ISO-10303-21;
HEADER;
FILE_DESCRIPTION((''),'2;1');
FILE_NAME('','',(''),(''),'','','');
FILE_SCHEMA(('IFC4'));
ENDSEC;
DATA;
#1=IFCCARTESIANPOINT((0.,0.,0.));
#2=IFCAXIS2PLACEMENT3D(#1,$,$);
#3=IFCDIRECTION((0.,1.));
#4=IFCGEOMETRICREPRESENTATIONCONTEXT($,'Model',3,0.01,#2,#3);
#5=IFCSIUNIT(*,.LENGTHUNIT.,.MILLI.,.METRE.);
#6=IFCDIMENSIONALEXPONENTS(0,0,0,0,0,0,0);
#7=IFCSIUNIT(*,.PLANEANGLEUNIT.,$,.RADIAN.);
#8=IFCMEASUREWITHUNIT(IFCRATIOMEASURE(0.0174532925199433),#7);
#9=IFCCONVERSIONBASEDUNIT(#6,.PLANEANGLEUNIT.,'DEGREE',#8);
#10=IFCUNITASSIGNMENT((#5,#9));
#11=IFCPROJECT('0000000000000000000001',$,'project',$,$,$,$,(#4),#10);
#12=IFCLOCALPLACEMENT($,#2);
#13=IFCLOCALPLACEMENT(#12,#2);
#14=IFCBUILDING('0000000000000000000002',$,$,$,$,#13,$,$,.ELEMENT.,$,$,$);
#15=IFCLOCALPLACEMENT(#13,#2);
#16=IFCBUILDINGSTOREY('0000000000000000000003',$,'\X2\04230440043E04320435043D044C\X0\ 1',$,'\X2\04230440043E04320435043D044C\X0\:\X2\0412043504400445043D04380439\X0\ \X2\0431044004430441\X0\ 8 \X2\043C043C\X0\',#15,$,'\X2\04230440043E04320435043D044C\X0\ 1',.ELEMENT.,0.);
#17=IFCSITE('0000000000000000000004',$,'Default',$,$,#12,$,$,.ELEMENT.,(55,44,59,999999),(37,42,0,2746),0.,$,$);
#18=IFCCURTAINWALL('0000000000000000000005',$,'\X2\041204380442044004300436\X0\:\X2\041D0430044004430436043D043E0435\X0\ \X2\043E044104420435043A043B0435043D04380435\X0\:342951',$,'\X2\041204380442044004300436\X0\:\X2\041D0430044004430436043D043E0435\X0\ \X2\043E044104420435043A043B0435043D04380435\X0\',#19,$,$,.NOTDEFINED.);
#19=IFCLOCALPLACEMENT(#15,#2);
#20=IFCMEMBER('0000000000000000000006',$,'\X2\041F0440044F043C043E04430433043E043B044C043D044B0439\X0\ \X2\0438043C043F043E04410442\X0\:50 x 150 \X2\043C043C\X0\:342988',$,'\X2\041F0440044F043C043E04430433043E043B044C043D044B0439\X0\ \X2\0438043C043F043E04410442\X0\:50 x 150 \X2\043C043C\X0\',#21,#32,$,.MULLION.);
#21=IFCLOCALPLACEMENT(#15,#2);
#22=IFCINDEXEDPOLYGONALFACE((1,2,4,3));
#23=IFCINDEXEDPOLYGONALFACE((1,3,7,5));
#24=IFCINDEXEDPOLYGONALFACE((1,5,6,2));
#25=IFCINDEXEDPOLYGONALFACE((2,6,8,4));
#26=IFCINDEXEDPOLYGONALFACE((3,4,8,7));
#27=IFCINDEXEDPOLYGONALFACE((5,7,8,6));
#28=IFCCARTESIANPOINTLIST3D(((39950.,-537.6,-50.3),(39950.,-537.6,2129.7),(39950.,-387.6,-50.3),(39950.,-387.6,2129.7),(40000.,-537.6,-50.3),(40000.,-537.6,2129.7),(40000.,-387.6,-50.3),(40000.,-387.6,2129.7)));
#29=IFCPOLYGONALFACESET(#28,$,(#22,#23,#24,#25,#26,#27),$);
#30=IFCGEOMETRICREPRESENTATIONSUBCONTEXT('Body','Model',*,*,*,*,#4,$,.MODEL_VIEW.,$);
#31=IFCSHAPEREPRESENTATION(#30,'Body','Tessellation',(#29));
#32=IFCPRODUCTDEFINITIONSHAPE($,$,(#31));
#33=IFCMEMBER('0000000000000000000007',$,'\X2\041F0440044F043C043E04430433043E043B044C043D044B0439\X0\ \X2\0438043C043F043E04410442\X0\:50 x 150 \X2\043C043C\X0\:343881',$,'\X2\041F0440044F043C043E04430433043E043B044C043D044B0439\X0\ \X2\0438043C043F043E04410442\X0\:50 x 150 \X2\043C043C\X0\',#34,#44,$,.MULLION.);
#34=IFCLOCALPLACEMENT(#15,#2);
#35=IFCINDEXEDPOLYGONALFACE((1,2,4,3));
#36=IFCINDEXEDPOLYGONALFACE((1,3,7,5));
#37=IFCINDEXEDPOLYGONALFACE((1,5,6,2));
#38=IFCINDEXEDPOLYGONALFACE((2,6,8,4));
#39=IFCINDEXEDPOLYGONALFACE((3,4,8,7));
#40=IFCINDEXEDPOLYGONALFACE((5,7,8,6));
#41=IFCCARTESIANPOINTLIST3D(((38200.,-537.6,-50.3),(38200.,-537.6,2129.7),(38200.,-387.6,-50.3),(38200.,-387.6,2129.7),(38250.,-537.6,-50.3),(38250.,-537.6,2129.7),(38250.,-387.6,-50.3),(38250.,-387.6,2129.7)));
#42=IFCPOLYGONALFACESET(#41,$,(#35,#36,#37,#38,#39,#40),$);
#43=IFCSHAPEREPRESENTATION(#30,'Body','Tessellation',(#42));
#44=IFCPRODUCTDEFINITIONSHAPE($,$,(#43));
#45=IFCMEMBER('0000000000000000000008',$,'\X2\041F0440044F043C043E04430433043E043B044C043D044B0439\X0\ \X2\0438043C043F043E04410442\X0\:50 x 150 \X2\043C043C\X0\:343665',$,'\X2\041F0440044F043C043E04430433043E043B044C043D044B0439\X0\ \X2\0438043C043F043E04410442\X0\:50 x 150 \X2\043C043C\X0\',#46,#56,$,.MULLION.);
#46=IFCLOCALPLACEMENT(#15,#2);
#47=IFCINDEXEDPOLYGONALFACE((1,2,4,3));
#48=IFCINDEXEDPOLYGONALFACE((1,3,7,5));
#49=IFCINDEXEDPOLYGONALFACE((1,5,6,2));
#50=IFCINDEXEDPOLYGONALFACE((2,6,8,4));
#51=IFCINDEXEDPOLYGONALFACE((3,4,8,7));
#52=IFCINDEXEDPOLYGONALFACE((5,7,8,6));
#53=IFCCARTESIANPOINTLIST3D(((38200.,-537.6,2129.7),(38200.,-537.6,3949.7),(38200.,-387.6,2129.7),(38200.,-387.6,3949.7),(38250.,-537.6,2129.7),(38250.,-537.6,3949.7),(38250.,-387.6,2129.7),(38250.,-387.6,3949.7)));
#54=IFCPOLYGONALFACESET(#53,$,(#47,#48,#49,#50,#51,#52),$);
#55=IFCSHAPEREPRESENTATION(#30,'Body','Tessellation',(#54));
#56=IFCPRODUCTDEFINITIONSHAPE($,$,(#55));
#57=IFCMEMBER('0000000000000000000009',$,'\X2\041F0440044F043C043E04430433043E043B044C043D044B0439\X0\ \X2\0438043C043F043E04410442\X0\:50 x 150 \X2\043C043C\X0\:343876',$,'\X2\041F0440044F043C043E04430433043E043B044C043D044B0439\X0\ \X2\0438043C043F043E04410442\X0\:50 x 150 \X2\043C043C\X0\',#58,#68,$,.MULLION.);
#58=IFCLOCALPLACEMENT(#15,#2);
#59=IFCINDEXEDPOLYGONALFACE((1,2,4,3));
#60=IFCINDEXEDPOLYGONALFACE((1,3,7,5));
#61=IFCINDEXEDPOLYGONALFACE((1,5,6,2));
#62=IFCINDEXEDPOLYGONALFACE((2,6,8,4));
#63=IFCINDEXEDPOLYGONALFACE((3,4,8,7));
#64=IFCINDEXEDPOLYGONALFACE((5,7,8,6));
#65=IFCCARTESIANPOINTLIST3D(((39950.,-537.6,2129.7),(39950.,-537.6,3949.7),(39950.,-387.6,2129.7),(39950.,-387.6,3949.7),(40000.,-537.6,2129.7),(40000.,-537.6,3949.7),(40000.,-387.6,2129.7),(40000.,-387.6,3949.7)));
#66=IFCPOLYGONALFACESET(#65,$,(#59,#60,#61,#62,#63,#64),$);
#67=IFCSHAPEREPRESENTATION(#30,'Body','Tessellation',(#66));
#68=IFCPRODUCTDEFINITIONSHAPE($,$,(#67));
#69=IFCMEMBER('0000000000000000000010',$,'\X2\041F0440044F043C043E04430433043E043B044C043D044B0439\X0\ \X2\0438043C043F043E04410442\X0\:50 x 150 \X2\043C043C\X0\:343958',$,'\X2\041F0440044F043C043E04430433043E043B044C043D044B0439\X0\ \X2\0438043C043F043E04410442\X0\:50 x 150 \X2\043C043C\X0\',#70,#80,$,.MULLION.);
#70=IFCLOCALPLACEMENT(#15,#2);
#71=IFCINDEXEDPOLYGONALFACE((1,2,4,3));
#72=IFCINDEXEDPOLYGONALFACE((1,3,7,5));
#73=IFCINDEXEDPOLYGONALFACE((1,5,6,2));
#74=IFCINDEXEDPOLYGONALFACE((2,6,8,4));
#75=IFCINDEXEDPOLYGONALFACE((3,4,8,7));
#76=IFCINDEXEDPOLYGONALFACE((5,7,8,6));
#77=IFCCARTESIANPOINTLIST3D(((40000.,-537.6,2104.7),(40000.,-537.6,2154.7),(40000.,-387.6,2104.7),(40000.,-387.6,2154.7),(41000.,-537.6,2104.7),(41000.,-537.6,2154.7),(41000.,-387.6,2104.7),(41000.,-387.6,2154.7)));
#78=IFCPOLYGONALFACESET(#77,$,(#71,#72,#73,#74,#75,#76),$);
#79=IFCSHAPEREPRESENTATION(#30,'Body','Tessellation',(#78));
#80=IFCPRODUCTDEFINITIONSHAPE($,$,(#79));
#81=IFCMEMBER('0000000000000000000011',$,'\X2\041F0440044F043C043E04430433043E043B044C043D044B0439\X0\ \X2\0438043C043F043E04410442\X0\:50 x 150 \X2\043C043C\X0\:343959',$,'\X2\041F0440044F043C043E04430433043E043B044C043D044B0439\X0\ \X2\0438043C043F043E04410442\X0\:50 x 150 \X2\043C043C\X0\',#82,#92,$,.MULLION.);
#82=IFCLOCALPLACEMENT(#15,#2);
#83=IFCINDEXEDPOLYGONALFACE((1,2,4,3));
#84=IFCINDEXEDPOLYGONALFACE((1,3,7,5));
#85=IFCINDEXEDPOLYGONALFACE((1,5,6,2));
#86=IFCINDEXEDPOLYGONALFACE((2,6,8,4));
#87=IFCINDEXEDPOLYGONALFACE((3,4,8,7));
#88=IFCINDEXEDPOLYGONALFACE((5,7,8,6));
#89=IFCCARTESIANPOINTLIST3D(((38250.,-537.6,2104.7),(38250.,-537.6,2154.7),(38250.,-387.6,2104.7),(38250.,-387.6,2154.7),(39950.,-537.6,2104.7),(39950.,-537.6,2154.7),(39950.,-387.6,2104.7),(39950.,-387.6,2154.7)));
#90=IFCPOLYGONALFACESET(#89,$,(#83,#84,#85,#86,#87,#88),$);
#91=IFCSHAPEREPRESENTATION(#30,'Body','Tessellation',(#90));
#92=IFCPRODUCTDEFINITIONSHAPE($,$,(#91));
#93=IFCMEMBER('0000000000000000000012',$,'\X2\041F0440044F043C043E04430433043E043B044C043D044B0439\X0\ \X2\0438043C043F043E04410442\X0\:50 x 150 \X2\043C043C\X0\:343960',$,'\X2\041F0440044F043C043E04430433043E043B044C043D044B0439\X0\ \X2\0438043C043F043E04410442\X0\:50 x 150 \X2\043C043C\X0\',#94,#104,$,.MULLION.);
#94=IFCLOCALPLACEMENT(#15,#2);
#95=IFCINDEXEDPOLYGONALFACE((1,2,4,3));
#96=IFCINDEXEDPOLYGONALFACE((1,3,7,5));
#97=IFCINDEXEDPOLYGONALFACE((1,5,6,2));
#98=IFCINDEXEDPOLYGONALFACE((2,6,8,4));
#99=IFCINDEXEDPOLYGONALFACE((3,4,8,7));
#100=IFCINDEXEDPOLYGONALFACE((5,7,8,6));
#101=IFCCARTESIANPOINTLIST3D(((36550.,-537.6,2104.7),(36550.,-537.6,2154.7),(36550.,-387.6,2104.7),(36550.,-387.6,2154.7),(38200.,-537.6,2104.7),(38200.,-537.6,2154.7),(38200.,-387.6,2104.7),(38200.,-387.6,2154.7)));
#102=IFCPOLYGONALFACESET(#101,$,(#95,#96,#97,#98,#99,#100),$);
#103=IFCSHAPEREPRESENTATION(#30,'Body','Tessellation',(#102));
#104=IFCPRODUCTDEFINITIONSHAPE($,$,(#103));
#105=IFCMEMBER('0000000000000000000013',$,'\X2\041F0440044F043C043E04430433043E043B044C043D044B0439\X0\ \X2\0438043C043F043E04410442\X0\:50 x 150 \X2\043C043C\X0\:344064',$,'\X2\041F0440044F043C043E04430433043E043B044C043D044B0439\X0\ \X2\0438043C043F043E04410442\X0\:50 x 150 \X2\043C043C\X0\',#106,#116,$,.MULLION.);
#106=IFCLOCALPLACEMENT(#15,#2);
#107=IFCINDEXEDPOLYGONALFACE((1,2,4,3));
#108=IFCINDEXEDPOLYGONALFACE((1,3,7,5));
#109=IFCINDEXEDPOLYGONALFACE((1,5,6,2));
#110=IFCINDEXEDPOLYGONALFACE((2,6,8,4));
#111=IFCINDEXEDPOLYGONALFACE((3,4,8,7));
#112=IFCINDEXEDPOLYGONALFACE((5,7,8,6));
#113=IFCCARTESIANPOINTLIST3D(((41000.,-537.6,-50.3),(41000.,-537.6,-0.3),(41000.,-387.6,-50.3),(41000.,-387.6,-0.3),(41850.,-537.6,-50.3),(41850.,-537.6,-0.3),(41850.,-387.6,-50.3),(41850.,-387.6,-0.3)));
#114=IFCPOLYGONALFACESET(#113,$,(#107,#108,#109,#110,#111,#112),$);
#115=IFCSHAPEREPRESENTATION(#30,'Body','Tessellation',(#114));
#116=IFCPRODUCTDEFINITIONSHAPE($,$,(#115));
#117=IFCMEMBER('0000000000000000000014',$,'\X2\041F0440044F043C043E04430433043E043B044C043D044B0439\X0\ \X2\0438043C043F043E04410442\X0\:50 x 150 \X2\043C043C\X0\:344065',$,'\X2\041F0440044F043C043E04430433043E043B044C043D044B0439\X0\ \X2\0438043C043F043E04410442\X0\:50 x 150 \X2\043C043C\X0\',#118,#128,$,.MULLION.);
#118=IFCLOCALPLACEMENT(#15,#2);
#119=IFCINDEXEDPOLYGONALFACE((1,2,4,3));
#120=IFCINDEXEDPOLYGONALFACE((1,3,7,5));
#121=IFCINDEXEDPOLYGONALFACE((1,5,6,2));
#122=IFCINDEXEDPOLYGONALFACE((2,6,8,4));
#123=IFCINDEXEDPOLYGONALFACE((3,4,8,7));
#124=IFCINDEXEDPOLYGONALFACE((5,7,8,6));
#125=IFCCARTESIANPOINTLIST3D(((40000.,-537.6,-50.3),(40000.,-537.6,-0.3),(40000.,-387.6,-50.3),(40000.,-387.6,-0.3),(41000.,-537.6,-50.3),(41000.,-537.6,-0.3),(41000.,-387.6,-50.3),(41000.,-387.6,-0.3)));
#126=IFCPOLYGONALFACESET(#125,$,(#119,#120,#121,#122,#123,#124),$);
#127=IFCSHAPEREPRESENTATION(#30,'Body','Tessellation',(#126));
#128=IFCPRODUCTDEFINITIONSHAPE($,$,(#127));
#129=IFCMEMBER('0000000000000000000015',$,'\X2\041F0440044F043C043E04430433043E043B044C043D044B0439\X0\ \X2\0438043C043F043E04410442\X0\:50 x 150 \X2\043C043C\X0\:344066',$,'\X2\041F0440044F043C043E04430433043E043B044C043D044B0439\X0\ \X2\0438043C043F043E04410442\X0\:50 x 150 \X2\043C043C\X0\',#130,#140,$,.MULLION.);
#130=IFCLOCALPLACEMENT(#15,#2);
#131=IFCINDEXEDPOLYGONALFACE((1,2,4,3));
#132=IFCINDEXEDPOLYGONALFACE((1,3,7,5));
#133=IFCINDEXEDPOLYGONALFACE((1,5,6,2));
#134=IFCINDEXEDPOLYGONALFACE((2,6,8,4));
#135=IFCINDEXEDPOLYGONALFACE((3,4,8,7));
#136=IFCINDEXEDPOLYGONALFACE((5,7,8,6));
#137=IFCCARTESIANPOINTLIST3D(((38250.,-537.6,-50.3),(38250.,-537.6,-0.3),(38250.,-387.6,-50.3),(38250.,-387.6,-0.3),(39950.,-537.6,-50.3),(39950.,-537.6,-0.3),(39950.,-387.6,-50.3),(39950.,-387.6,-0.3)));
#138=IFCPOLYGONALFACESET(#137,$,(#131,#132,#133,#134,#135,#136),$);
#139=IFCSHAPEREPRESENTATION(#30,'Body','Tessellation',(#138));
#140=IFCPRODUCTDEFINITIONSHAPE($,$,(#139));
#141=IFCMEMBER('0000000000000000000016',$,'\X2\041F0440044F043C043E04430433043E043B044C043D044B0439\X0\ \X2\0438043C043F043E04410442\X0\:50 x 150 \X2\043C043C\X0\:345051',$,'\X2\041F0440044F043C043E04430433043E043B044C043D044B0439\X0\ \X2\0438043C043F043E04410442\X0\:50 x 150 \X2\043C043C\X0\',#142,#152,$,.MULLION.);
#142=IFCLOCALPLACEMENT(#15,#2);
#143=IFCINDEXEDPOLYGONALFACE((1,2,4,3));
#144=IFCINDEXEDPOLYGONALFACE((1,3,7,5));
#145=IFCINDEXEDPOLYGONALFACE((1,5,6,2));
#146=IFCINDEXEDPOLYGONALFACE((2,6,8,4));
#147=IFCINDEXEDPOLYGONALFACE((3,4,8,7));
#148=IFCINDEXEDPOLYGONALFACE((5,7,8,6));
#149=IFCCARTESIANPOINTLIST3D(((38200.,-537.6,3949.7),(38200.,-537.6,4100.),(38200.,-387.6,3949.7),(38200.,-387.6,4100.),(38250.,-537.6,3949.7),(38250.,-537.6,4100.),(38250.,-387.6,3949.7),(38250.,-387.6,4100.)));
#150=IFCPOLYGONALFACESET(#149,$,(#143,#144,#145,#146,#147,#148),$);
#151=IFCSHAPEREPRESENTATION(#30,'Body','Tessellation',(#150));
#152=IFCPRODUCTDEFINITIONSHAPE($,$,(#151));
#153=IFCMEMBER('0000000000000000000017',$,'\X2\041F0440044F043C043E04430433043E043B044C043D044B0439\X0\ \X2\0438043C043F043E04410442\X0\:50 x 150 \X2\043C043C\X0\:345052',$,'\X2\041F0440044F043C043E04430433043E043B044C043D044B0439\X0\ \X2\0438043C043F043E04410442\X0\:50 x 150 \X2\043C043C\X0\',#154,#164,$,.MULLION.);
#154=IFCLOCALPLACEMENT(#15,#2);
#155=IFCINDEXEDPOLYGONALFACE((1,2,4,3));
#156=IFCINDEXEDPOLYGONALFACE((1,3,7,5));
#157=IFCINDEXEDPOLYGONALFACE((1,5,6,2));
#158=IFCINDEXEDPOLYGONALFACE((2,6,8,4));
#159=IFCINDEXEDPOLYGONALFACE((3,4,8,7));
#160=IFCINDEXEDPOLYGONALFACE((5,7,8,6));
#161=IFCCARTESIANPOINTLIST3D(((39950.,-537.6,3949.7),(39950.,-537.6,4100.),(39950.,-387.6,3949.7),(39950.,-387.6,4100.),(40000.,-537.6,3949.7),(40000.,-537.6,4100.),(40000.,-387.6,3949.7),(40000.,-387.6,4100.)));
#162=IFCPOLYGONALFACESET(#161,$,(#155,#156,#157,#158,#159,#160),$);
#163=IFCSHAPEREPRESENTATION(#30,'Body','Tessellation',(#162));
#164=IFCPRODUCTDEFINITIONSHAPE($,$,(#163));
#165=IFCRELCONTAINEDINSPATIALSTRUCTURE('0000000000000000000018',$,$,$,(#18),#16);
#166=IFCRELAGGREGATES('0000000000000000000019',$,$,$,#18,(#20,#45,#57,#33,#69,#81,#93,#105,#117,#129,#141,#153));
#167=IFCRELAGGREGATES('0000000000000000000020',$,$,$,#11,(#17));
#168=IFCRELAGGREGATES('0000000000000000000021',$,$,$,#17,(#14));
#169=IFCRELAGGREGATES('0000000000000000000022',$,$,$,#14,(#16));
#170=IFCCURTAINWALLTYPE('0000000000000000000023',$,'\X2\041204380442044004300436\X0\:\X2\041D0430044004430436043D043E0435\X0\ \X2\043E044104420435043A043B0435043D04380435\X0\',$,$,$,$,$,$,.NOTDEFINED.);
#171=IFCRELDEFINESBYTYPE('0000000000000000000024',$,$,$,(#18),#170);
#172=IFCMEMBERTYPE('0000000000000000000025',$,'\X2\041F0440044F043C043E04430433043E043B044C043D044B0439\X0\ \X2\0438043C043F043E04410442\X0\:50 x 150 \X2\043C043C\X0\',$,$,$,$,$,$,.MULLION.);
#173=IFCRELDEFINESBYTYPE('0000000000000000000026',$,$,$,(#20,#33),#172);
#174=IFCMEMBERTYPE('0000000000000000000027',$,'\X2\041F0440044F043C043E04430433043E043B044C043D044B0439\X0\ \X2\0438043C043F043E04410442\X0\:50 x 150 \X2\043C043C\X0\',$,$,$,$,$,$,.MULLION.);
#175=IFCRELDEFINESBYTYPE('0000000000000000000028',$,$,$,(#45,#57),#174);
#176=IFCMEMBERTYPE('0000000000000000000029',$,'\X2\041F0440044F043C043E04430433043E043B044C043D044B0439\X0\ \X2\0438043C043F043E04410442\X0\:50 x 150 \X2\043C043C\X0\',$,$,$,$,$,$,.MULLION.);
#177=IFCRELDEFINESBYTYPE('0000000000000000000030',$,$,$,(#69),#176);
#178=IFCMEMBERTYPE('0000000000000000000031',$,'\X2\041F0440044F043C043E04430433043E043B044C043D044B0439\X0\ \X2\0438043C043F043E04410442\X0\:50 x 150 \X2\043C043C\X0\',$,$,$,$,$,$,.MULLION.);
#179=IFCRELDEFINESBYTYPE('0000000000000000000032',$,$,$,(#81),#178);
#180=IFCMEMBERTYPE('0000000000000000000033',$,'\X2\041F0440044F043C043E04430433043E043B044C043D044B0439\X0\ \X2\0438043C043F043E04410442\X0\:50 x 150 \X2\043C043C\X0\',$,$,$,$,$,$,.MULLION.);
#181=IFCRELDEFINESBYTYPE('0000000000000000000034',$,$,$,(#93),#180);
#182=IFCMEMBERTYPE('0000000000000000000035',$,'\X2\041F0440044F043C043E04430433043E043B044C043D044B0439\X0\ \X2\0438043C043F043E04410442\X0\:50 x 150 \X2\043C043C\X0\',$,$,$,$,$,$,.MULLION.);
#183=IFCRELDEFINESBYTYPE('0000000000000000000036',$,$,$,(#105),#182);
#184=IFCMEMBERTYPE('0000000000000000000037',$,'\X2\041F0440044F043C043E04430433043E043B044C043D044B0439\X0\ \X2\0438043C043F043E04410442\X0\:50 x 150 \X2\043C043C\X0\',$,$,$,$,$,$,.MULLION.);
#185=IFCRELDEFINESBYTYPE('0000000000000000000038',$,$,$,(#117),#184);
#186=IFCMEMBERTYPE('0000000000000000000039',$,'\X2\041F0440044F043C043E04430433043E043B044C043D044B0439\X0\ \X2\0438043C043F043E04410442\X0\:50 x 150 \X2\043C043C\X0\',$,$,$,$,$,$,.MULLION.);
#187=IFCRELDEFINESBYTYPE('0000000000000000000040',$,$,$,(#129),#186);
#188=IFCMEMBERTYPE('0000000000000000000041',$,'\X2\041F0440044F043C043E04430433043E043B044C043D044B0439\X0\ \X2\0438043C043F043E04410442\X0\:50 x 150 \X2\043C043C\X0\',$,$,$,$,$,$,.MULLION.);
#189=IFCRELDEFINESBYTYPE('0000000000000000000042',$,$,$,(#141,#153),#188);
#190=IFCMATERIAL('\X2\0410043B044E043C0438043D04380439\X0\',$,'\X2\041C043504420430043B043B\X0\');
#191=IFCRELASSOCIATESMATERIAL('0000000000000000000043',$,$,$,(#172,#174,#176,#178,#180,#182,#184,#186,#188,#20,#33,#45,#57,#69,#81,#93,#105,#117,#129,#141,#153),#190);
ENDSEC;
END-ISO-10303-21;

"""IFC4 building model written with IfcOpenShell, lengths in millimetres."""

from ifc_helpers import new_model, entity, si_unit, converted_unit, direction, frame, origin, origin_2d_with_axis, place, context, subcontext, project, spatial, rectangle, extrude, source, transform, mapped, material, material_profile, profile_set, profile_usage, type_object, type_shapes, element, aggregate, save


model = new_model("IFC4")

# Units and contexts
model_context = context("Model", 3, precision=0.01, world=origin(), true_north=direction((0.0, 1.0)))
body_context = subcontext(model_context, "Body", "Model", "MODEL_VIEW")
ifc_project = project(units=[si_unit("LENGTHUNIT", "METRE", prefix="MILLI"), converted_unit("PLANEANGLEUNIT", "DEGREE", entity("IfcRatioMeasure", 0.0174532925199433), si_unit("PLANEANGLEUNIT", "RADIAN"), dimensions=[0, 0, 0, 0, 0, 0, 0])], contexts=[model_context])

# Site, building, storey
site_placement = place(None, origin())
site = spatial("IfcSite", under=ifc_project, at=site_placement, Name="Default", CompositionType="ELEMENT", RefLatitude=(55, 44, 59, 999999), RefLongitude=(37, 42, 0, 2746), RefElevation=0.0)
building_placement = place(site_placement, origin())
building = spatial("IfcBuilding", under=site, at=building_placement, CompositionType="ELEMENT")
storey_placement = place(building_placement, origin())
storey = spatial("IfcBuildingStorey", under=building, at=storey_placement, Name="Уровень 1", ObjectType="Уровень:Верхний брус 8 мм", LongName="Уровень 1", CompositionType="ELEMENT", Elevation=0.0)

# Curtain wall, members
curtain_wall_type = type_object("IfcCurtainWallType", Name="Витраж:Наружное остекление", PredefinedType="NOTDEFINED")
curtain_wall_placement = place(storey_placement, origin())
curtain_wall = element("IfcCurtainWall", 1, at=curtain_wall_placement, inside=storey, type_object=curtain_wall_type, Name="Витраж:Наружное остекление:342951", ObjectType="Витраж:Наружное остекление", PredefinedType="NOTDEFINED")
ifc_material_1 = material(Name="Алюминий", Category="Металл")
ifc_material_profile = material_profile(ifc_material_1, rectangle(XDim=150.0, YDim=50.0, at=origin_2d_with_axis()), Name="50 x 150 мм")
ifc_profile_set = profile_set([ifc_material_profile], Name="50 x 150 мм")
ifc_profile_usage_1 = profile_usage(ifc_profile_set)
member_type_1 = type_object("IfcMemberType", Name="Прямоугольный импост:50 x 150 мм", PredefinedType="MULLION", material=ifc_profile_set)
shared_shape_1 = source(origin(), body_context, "Body", "SweptSolid", [
    extrude(rectangle(XDim=150.0, YDim=50.0, at=origin_2d_with_axis()), frame((0.0, 0.0, -2180.0), z_axis=(0.0, 0.0, 1.0), x_axis=(0.0, -1.0, 0.0)), (0.0, 0.0, 1.0), 2180.0),
])
type_shapes(member_type_1, [shared_shape_1])
member_1_placement = place(storey_placement, frame((39975.0, -462.6, -50.3), z_axis=(0.0, 0.0, -1.0), x_axis=(1.0, 0.0, 0.0)))
member_1 = element("IfcMember", 2, at=member_1_placement, type_object=member_type_1, material=ifc_profile_usage_1, Name="Прямоугольный импост:50 x 150 мм:342988", ObjectType="Прямоугольный импост:50 x 150 мм", PredefinedType="MULLION", context=body_context, shape_type="MappedRepresentation", body=[
    mapped(shared_shape_1, transform((0.0, 0.0, 0.0), scale=1.0)),
])
ifc_profile_usage_2 = profile_usage(ifc_profile_set)
member_2_placement = place(storey_placement, frame((38225.0, -462.6, -50.3), z_axis=(0.0, 0.0, -1.0), x_axis=(1.0, 0.0, 0.0)))
member_2 = element("IfcMember", 3, at=member_2_placement, type_object=member_type_1, material=ifc_profile_usage_2, Name="Прямоугольный импост:50 x 150 мм:343881", ObjectType="Прямоугольный импост:50 x 150 мм", PredefinedType="MULLION", context=body_context, shape_type="MappedRepresentation", body=[
    mapped(shared_shape_1, transform((0.0, 0.0, 0.0), scale=1.0)),
])
ifc_profile_usage_3 = profile_usage(ifc_profile_set)
member_type_2 = type_object("IfcMemberType", Name="Прямоугольный импост:50 x 150 мм", PredefinedType="MULLION", material=ifc_profile_set)
shared_shape_2 = source(origin(), body_context, "Body", "SweptSolid", [
    extrude(rectangle(XDim=150.0, YDim=50.0, at=origin_2d_with_axis()), frame((0.0, 0.0, -1820.0), z_axis=(0.0, 0.0, 1.0), x_axis=(0.0, -1.0, 0.0)), (0.0, 0.0, 1.0), 1820.0),
])
type_shapes(member_type_2, [shared_shape_2])
member_3_placement = place(storey_placement, frame((38225.0, -462.6, 2129.7), z_axis=(0.0, 0.0, -1.0), x_axis=(1.0, 0.0, 0.0)))
member_3 = element("IfcMember", 4, at=member_3_placement, type_object=member_type_2, material=ifc_profile_usage_3, Name="Прямоугольный импост:50 x 150 мм:343665", ObjectType="Прямоугольный импост:50 x 150 мм", PredefinedType="MULLION", context=body_context, shape_type="MappedRepresentation", body=[
    mapped(shared_shape_2, transform((0.0, 0.0, 0.0), scale=1.0)),
])
ifc_profile_usage_4 = profile_usage(ifc_profile_set)
member_4_placement = place(storey_placement, frame((39975.0, -462.6, 2129.7), z_axis=(0.0, 0.0, -1.0), x_axis=(1.0, 0.0, 0.0)))
member_4 = element("IfcMember", 5, at=member_4_placement, type_object=member_type_2, material=ifc_profile_usage_4, Name="Прямоугольный импост:50 x 150 мм:343876", ObjectType="Прямоугольный импост:50 x 150 мм", PredefinedType="MULLION", context=body_context, shape_type="MappedRepresentation", body=[
    mapped(shared_shape_2, transform((0.0, 0.0, 0.0), scale=1.0)),
])
ifc_profile_usage_5 = profile_usage(ifc_profile_set)
member_type_3 = type_object("IfcMemberType", Name="Прямоугольный импост:50 x 150 мм", PredefinedType="MULLION", material=ifc_profile_set)
shared_shape_3 = source(origin(), body_context, "Body", "SweptSolid", [
    extrude(rectangle(XDim=150.0, YDim=50.0, at=origin_2d_with_axis()), frame((0.0, 0.0, -1000.0), z_axis=(0.0, 0.0, 1.0), x_axis=(0.0, -1.0, 0.0)), (0.0, 0.0, 1.0), 1000.0),
])
type_shapes(member_type_3, [shared_shape_3])
member_5_placement = place(storey_placement, frame((41000.0, -462.6, 2129.7), z_axis=(1.0, 0.0, 0.0), x_axis=(0.0, 0.0, 1.0)))
member_5 = element("IfcMember", 6, at=member_5_placement, type_object=member_type_3, material=ifc_profile_usage_5, Name="Прямоугольный импост:50 x 150 мм:343958", ObjectType="Прямоугольный импост:50 x 150 мм", PredefinedType="MULLION", context=body_context, shape_type="MappedRepresentation", body=[
    mapped(shared_shape_3, transform((0.0, 0.0, 0.0), scale=1.0)),
])
ifc_profile_usage_6 = profile_usage(ifc_profile_set)
member_type_4 = type_object("IfcMemberType", Name="Прямоугольный импост:50 x 150 мм", PredefinedType="MULLION", material=ifc_profile_set)
shared_shape_4 = source(origin(), body_context, "Body", "SweptSolid", [
    extrude(rectangle(XDim=150.0, YDim=50.0, at=origin_2d_with_axis()), frame((0.0, 0.0, -1700.0), z_axis=(0.0, 0.0, 1.0), x_axis=(0.0, -1.0, 0.0)), (0.0, 0.0, 1.0), 1700.0),
])
type_shapes(member_type_4, [shared_shape_4])
member_6_placement = place(storey_placement, frame((39950.0, -462.6, 2129.7), z_axis=(1.0, 0.0, 0.0), x_axis=(0.0, 0.0, 1.0)))
member_6 = element("IfcMember", 7, at=member_6_placement, type_object=member_type_4, material=ifc_profile_usage_6, Name="Прямоугольный импост:50 x 150 мм:343959", ObjectType="Прямоугольный импост:50 x 150 мм", PredefinedType="MULLION", context=body_context, shape_type="MappedRepresentation", body=[
    mapped(shared_shape_4, transform((0.0, 0.0, 0.0), scale=1.0)),
])
ifc_profile_usage_7 = profile_usage(ifc_profile_set)
member_type_5 = type_object("IfcMemberType", Name="Прямоугольный импост:50 x 150 мм", PredefinedType="MULLION", material=ifc_profile_set)
shared_shape_5 = source(origin(), body_context, "Body", "SweptSolid", [
    extrude(rectangle(XDim=150.0, YDim=50.0, at=origin_2d_with_axis()), frame((0.0, 0.0, -1650.0), z_axis=(0.0, 0.0, 1.0), x_axis=(0.0, -1.0, 0.0)), (0.0, 0.0, 1.0), 1650.0),
])
type_shapes(member_type_5, [shared_shape_5])
member_7_placement = place(storey_placement, frame((38200.0, -462.6, 2129.7), z_axis=(1.0, 0.0, 0.0), x_axis=(0.0, 0.0, 1.0)))
member_7 = element("IfcMember", 8, at=member_7_placement, type_object=member_type_5, material=ifc_profile_usage_7, Name="Прямоугольный импост:50 x 150 мм:343960", ObjectType="Прямоугольный импост:50 x 150 мм", PredefinedType="MULLION", context=body_context, shape_type="MappedRepresentation", body=[
    mapped(shared_shape_5, transform((0.0, 0.0, 0.0), scale=1.0)),
])
ifc_profile_usage_8 = profile_usage(ifc_profile_set)
member_type_6 = type_object("IfcMemberType", Name="Прямоугольный импост:50 x 150 мм", PredefinedType="MULLION", material=ifc_profile_set)
shared_shape_6 = source(origin(), body_context, "Body", "SweptSolid", [
    extrude(rectangle(XDim=150.0, YDim=50.0, at=origin_2d_with_axis()), frame((-25.0, 0.0, -850.0), z_axis=(0.0, 0.0, 1.0), x_axis=(0.0, -1.0, 0.0)), (0.0, 0.0, 1.0), 850.0),
])
type_shapes(member_type_6, [shared_shape_6])
member_8_placement = place(storey_placement, frame((41000.0, -462.6, -50.3), z_axis=(-1.0, 0.0, 0.0), x_axis=(0.0, 0.0, -1.0)))
member_8 = element("IfcMember", 9, at=member_8_placement, type_object=member_type_6, material=ifc_profile_usage_8, Name="Прямоугольный импост:50 x 150 мм:344064", ObjectType="Прямоугольный импост:50 x 150 мм", PredefinedType="MULLION", context=body_context, shape_type="MappedRepresentation", body=[
    mapped(shared_shape_6, transform((0.0, 0.0, 0.0), scale=1.0)),
])
ifc_profile_usage_9 = profile_usage(ifc_profile_set)
member_type_7 = type_object("IfcMemberType", Name="Прямоугольный импост:50 x 150 мм", PredefinedType="MULLION", material=ifc_profile_set)
shared_shape_7 = source(origin(), body_context, "Body", "SweptSolid", [
    extrude(rectangle(XDim=150.0, YDim=50.0, at=origin_2d_with_axis()), frame((-25.0, 0.0, -1000.0), z_axis=(0.0, 0.0, 1.0), x_axis=(0.0, -1.0, 0.0)), (0.0, 0.0, 1.0), 1000.0),
])
type_shapes(member_type_7, [shared_shape_7])
member_9_placement = place(storey_placement, frame((40000.0, -462.6, -50.3), z_axis=(-1.0, 0.0, 0.0), x_axis=(0.0, 0.0, -1.0)))
member_9 = element("IfcMember", 10, at=member_9_placement, type_object=member_type_7, material=ifc_profile_usage_9, Name="Прямоугольный импост:50 x 150 мм:344065", ObjectType="Прямоугольный импост:50 x 150 мм", PredefinedType="MULLION", context=body_context, shape_type="MappedRepresentation", body=[
    mapped(shared_shape_7, transform((0.0, 0.0, 0.0), scale=1.0)),
])
ifc_profile_usage_10 = profile_usage(ifc_profile_set)
member_type_8 = type_object("IfcMemberType", Name="Прямоугольный импост:50 x 150 мм", PredefinedType="MULLION", material=ifc_profile_set)
shared_shape_8 = source(origin(), body_context, "Body", "SweptSolid", [
    extrude(rectangle(XDim=150.0, YDim=50.0, at=origin_2d_with_axis()), frame((-25.0, 0.0, -1700.0), z_axis=(0.0, 0.0, 1.0), x_axis=(0.0, -1.0, 0.0)), (0.0, 0.0, 1.0), 1700.0),
])
type_shapes(member_type_8, [shared_shape_8])
member_10_placement = place(storey_placement, frame((38250.0, -462.6, -50.3), z_axis=(-1.0, 0.0, 0.0), x_axis=(0.0, 0.0, -1.0)))
member_10 = element("IfcMember", 11, at=member_10_placement, type_object=member_type_8, material=ifc_profile_usage_10, Name="Прямоугольный импост:50 x 150 мм:344066", ObjectType="Прямоугольный импост:50 x 150 мм", PredefinedType="MULLION", context=body_context, shape_type="MappedRepresentation", body=[
    mapped(shared_shape_8, transform((0.0, 0.0, 0.0), scale=1.0)),
])
ifc_profile_usage_11 = profile_usage(ifc_profile_set)
member_type_9 = type_object("IfcMemberType", Name="Прямоугольный импост:50 x 150 мм", PredefinedType="MULLION", material=ifc_profile_set)
shared_shape_9 = source(origin(), body_context, "Body", "SweptSolid", [
    extrude(rectangle(XDim=150.0, YDim=50.0, at=origin_2d_with_axis()), frame((0.0, 0.0, -150.3), z_axis=(0.0, 0.0, 1.0), x_axis=(0.0, -1.0, 0.0)), (0.0, 0.0, 1.0), 150.3),
])
type_shapes(member_type_9, [shared_shape_9])
member_11_placement = place(storey_placement, frame((38225.0, -462.6, 3949.7), z_axis=(0.0, 0.0, -1.0), x_axis=(1.0, 0.0, 0.0)))
member_11 = element("IfcMember", 12, at=member_11_placement, type_object=member_type_9, material=ifc_profile_usage_11, Name="Прямоугольный импост:50 x 150 мм:345051", ObjectType="Прямоугольный импост:50 x 150 мм", PredefinedType="MULLION", context=body_context, shape_type="MappedRepresentation", body=[
    mapped(shared_shape_9, transform((0.0, 0.0, 0.0), scale=1.0)),
])
ifc_profile_usage_12 = profile_usage(ifc_profile_set)
member_12_placement = place(storey_placement, frame((39975.0, -462.6, 3949.7), z_axis=(0.0, 0.0, -1.0), x_axis=(1.0, 0.0, 0.0)))
member_12 = element("IfcMember", 13, at=member_12_placement, type_object=member_type_9, material=ifc_profile_usage_12, Name="Прямоугольный импост:50 x 150 мм:345052", ObjectType="Прямоугольный импост:50 x 150 мм", PredefinedType="MULLION", context=body_context, shape_type="MappedRepresentation", body=[
    mapped(shared_shape_9, transform((0.0, 0.0, 0.0), scale=1.0)),
])
aggregate(curtain_wall, [member_1, member_3, member_4, member_2, member_5, member_6, member_7, member_8, member_9, member_10, member_11, member_12])

save(model, "model.ifc")
